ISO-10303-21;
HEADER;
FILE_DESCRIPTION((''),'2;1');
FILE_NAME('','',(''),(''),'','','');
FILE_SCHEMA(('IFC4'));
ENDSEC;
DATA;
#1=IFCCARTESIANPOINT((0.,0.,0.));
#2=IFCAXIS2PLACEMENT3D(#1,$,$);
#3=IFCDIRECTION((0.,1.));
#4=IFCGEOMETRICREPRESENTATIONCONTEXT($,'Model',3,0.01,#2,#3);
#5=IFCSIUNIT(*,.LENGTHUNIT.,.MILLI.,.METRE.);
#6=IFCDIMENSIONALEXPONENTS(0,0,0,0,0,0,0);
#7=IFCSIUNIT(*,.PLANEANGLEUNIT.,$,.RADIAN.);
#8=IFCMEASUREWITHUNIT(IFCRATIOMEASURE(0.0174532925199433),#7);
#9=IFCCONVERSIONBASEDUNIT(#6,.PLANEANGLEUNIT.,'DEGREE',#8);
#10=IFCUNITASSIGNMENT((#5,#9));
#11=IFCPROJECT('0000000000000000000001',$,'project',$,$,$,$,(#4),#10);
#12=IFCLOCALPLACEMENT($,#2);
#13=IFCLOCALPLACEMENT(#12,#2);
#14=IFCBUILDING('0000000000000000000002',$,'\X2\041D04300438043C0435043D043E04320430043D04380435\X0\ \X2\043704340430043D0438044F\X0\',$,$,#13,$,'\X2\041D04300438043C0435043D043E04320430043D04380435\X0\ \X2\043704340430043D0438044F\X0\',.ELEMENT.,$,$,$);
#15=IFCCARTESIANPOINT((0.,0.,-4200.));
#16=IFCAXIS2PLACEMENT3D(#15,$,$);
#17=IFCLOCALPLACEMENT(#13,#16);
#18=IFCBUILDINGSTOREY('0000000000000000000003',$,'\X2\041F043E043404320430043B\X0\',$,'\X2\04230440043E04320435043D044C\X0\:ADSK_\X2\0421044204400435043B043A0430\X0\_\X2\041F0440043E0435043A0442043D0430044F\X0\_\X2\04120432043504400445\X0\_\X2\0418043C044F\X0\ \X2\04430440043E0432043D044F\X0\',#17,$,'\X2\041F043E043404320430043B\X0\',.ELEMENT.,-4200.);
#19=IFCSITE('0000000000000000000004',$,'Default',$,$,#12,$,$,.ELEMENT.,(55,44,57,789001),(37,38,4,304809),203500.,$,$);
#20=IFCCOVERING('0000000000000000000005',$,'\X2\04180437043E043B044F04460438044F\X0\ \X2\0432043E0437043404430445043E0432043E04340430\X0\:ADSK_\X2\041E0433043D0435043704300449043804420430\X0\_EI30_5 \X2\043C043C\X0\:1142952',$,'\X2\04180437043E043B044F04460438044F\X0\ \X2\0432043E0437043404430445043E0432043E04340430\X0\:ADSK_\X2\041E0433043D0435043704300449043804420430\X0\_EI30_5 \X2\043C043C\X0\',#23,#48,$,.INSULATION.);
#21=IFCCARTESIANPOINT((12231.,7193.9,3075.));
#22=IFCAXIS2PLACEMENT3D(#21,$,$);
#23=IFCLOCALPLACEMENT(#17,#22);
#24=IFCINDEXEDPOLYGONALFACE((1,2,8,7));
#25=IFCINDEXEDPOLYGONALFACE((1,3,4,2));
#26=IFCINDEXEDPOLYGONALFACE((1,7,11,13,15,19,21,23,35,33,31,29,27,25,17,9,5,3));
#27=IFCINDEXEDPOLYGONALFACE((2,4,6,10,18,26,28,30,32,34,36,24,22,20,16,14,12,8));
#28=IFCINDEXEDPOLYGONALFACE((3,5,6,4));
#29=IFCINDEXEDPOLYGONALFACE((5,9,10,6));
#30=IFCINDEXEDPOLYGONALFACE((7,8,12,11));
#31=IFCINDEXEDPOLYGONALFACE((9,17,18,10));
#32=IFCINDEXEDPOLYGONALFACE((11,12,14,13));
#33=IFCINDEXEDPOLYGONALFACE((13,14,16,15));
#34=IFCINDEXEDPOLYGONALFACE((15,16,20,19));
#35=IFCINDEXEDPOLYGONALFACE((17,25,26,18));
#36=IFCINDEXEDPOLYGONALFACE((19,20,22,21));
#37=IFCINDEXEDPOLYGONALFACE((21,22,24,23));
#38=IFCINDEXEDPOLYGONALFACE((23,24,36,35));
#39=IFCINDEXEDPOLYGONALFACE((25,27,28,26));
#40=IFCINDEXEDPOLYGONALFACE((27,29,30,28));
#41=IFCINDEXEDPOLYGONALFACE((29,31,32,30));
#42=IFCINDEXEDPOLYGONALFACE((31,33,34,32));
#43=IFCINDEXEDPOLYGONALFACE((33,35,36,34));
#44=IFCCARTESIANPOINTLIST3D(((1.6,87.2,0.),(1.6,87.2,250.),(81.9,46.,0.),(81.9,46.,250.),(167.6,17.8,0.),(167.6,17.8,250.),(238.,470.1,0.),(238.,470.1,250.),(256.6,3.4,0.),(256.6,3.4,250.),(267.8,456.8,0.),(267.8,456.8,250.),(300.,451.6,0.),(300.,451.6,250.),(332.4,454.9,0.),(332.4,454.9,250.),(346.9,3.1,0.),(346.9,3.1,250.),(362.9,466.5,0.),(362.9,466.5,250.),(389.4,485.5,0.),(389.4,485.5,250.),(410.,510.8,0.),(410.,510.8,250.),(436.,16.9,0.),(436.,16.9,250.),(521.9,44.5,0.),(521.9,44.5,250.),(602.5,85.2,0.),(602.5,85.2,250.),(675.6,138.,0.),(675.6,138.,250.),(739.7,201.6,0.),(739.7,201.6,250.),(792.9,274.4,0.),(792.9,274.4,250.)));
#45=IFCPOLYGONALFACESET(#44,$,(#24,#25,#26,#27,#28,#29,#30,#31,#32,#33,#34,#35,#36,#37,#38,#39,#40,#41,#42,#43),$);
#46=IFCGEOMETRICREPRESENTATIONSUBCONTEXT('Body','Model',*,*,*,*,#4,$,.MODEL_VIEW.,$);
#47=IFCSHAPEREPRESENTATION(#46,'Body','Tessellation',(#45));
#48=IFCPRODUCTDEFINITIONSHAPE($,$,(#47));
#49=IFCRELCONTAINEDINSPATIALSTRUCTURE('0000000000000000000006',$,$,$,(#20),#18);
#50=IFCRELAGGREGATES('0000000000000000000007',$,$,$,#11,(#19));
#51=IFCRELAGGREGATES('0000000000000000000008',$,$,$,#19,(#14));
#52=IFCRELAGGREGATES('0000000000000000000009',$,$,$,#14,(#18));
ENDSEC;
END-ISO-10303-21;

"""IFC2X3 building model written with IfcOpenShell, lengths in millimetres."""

from ifc_helpers import new_model, entity, si_unit, converted_unit, direction, frame, frame_2d, origin, place, context, subcontext, project, spatial, polyline, circle_curve, parameter, trimmed, segment, composite_curve, outline, extrude, element, save


model = new_model("IFC2X3")

# Units and contexts
model_context = context("Model", 3, precision=0.01, world=origin(), true_north=direction((0.0, 1.0)))
body_context = subcontext(model_context, "Body", "Model", "MODEL_VIEW")
ifc_project = project(units=[si_unit("LENGTHUNIT", "METRE", prefix="MILLI"), converted_unit("PLANEANGLEUNIT", "DEGREE", entity("IfcRatioMeasure", 0.0174532925199433), si_unit("PLANEANGLEUNIT", "RADIAN"), dimensions=[0, 0, 0, 0, 0, 0, 0])], contexts=[model_context])

# Site, building, storey
site_placement = place(None, origin())
site = spatial("IfcSite", under=ifc_project, at=site_placement, Name="Default", CompositionType="ELEMENT", RefLatitude=(55, 44, 57, 789001), RefLongitude=(37, 38, 4, 304809), RefElevation=203500.0)
building_placement = place(site_placement, origin())
building = spatial("IfcBuilding", under=site, at=building_placement, Name="Наименование здания", LongName="Наименование здания", CompositionType="ELEMENT")
storey_placement = place(building_placement, frame((0.0, 0.0, -4200.0)))
storey = spatial("IfcBuildingStorey", under=building, at=storey_placement, Name="Подвал", ObjectType="Уровень:ADSK_Стрелка_Проектная_Вверх_Имя уровня", LongName="Подвал", CompositionType="ELEMENT", Elevation=-4200.0)

# Covering
covering_1_placement = place(storey_placement, frame((12231.0, 7193.9, 3075.0)))
element("IfcCovering", 1, at=covering_1_placement, inside=storey, Name="Изоляция воздуховода:ADSK_Огнезащита_EI30_5 мм:1142952", ObjectType="Изоляция воздуховода:ADSK_Огнезащита_EI30_5 мм", PredefinedType="INSULATION", context=body_context, shape_type="SweptSolid", body=[
    extrude(outline(composite_curve([segment(polyline([(-175.0, 50.0), (-175.0, -400.0)]), True, "CONTINUOUS"), segment(trimmed(circle_curve(frame_2d((-175.0, 175.0), x_axis=(1.0, 0.0)), 575.0), [parameter(270.0)], [parameter(0.0)], True, "PARAMETER"), True, "CONTINUOUS"), segment(polyline([(400.0, 175.0), (-50.0, 175.0)]), True, "CONTINUOUS"), segment(trimmed(circle_curve(frame_2d((-175.0, 175.0), x_axis=(1.0, 0.0)), 125.0), [parameter(270.0)], [parameter(360.0)], True, "PARAMETER"), False, "CONTINUOUS")], self_intersect=False)), frame((360.6, 335.7, 0.0), z_axis=(0.0, 0.0, -1.0), x_axis=(-0.525347, -0.850888, 0.0)), (0.0, 0.0, -1.0), 250.0),
])

save(model, "model.ifc")
